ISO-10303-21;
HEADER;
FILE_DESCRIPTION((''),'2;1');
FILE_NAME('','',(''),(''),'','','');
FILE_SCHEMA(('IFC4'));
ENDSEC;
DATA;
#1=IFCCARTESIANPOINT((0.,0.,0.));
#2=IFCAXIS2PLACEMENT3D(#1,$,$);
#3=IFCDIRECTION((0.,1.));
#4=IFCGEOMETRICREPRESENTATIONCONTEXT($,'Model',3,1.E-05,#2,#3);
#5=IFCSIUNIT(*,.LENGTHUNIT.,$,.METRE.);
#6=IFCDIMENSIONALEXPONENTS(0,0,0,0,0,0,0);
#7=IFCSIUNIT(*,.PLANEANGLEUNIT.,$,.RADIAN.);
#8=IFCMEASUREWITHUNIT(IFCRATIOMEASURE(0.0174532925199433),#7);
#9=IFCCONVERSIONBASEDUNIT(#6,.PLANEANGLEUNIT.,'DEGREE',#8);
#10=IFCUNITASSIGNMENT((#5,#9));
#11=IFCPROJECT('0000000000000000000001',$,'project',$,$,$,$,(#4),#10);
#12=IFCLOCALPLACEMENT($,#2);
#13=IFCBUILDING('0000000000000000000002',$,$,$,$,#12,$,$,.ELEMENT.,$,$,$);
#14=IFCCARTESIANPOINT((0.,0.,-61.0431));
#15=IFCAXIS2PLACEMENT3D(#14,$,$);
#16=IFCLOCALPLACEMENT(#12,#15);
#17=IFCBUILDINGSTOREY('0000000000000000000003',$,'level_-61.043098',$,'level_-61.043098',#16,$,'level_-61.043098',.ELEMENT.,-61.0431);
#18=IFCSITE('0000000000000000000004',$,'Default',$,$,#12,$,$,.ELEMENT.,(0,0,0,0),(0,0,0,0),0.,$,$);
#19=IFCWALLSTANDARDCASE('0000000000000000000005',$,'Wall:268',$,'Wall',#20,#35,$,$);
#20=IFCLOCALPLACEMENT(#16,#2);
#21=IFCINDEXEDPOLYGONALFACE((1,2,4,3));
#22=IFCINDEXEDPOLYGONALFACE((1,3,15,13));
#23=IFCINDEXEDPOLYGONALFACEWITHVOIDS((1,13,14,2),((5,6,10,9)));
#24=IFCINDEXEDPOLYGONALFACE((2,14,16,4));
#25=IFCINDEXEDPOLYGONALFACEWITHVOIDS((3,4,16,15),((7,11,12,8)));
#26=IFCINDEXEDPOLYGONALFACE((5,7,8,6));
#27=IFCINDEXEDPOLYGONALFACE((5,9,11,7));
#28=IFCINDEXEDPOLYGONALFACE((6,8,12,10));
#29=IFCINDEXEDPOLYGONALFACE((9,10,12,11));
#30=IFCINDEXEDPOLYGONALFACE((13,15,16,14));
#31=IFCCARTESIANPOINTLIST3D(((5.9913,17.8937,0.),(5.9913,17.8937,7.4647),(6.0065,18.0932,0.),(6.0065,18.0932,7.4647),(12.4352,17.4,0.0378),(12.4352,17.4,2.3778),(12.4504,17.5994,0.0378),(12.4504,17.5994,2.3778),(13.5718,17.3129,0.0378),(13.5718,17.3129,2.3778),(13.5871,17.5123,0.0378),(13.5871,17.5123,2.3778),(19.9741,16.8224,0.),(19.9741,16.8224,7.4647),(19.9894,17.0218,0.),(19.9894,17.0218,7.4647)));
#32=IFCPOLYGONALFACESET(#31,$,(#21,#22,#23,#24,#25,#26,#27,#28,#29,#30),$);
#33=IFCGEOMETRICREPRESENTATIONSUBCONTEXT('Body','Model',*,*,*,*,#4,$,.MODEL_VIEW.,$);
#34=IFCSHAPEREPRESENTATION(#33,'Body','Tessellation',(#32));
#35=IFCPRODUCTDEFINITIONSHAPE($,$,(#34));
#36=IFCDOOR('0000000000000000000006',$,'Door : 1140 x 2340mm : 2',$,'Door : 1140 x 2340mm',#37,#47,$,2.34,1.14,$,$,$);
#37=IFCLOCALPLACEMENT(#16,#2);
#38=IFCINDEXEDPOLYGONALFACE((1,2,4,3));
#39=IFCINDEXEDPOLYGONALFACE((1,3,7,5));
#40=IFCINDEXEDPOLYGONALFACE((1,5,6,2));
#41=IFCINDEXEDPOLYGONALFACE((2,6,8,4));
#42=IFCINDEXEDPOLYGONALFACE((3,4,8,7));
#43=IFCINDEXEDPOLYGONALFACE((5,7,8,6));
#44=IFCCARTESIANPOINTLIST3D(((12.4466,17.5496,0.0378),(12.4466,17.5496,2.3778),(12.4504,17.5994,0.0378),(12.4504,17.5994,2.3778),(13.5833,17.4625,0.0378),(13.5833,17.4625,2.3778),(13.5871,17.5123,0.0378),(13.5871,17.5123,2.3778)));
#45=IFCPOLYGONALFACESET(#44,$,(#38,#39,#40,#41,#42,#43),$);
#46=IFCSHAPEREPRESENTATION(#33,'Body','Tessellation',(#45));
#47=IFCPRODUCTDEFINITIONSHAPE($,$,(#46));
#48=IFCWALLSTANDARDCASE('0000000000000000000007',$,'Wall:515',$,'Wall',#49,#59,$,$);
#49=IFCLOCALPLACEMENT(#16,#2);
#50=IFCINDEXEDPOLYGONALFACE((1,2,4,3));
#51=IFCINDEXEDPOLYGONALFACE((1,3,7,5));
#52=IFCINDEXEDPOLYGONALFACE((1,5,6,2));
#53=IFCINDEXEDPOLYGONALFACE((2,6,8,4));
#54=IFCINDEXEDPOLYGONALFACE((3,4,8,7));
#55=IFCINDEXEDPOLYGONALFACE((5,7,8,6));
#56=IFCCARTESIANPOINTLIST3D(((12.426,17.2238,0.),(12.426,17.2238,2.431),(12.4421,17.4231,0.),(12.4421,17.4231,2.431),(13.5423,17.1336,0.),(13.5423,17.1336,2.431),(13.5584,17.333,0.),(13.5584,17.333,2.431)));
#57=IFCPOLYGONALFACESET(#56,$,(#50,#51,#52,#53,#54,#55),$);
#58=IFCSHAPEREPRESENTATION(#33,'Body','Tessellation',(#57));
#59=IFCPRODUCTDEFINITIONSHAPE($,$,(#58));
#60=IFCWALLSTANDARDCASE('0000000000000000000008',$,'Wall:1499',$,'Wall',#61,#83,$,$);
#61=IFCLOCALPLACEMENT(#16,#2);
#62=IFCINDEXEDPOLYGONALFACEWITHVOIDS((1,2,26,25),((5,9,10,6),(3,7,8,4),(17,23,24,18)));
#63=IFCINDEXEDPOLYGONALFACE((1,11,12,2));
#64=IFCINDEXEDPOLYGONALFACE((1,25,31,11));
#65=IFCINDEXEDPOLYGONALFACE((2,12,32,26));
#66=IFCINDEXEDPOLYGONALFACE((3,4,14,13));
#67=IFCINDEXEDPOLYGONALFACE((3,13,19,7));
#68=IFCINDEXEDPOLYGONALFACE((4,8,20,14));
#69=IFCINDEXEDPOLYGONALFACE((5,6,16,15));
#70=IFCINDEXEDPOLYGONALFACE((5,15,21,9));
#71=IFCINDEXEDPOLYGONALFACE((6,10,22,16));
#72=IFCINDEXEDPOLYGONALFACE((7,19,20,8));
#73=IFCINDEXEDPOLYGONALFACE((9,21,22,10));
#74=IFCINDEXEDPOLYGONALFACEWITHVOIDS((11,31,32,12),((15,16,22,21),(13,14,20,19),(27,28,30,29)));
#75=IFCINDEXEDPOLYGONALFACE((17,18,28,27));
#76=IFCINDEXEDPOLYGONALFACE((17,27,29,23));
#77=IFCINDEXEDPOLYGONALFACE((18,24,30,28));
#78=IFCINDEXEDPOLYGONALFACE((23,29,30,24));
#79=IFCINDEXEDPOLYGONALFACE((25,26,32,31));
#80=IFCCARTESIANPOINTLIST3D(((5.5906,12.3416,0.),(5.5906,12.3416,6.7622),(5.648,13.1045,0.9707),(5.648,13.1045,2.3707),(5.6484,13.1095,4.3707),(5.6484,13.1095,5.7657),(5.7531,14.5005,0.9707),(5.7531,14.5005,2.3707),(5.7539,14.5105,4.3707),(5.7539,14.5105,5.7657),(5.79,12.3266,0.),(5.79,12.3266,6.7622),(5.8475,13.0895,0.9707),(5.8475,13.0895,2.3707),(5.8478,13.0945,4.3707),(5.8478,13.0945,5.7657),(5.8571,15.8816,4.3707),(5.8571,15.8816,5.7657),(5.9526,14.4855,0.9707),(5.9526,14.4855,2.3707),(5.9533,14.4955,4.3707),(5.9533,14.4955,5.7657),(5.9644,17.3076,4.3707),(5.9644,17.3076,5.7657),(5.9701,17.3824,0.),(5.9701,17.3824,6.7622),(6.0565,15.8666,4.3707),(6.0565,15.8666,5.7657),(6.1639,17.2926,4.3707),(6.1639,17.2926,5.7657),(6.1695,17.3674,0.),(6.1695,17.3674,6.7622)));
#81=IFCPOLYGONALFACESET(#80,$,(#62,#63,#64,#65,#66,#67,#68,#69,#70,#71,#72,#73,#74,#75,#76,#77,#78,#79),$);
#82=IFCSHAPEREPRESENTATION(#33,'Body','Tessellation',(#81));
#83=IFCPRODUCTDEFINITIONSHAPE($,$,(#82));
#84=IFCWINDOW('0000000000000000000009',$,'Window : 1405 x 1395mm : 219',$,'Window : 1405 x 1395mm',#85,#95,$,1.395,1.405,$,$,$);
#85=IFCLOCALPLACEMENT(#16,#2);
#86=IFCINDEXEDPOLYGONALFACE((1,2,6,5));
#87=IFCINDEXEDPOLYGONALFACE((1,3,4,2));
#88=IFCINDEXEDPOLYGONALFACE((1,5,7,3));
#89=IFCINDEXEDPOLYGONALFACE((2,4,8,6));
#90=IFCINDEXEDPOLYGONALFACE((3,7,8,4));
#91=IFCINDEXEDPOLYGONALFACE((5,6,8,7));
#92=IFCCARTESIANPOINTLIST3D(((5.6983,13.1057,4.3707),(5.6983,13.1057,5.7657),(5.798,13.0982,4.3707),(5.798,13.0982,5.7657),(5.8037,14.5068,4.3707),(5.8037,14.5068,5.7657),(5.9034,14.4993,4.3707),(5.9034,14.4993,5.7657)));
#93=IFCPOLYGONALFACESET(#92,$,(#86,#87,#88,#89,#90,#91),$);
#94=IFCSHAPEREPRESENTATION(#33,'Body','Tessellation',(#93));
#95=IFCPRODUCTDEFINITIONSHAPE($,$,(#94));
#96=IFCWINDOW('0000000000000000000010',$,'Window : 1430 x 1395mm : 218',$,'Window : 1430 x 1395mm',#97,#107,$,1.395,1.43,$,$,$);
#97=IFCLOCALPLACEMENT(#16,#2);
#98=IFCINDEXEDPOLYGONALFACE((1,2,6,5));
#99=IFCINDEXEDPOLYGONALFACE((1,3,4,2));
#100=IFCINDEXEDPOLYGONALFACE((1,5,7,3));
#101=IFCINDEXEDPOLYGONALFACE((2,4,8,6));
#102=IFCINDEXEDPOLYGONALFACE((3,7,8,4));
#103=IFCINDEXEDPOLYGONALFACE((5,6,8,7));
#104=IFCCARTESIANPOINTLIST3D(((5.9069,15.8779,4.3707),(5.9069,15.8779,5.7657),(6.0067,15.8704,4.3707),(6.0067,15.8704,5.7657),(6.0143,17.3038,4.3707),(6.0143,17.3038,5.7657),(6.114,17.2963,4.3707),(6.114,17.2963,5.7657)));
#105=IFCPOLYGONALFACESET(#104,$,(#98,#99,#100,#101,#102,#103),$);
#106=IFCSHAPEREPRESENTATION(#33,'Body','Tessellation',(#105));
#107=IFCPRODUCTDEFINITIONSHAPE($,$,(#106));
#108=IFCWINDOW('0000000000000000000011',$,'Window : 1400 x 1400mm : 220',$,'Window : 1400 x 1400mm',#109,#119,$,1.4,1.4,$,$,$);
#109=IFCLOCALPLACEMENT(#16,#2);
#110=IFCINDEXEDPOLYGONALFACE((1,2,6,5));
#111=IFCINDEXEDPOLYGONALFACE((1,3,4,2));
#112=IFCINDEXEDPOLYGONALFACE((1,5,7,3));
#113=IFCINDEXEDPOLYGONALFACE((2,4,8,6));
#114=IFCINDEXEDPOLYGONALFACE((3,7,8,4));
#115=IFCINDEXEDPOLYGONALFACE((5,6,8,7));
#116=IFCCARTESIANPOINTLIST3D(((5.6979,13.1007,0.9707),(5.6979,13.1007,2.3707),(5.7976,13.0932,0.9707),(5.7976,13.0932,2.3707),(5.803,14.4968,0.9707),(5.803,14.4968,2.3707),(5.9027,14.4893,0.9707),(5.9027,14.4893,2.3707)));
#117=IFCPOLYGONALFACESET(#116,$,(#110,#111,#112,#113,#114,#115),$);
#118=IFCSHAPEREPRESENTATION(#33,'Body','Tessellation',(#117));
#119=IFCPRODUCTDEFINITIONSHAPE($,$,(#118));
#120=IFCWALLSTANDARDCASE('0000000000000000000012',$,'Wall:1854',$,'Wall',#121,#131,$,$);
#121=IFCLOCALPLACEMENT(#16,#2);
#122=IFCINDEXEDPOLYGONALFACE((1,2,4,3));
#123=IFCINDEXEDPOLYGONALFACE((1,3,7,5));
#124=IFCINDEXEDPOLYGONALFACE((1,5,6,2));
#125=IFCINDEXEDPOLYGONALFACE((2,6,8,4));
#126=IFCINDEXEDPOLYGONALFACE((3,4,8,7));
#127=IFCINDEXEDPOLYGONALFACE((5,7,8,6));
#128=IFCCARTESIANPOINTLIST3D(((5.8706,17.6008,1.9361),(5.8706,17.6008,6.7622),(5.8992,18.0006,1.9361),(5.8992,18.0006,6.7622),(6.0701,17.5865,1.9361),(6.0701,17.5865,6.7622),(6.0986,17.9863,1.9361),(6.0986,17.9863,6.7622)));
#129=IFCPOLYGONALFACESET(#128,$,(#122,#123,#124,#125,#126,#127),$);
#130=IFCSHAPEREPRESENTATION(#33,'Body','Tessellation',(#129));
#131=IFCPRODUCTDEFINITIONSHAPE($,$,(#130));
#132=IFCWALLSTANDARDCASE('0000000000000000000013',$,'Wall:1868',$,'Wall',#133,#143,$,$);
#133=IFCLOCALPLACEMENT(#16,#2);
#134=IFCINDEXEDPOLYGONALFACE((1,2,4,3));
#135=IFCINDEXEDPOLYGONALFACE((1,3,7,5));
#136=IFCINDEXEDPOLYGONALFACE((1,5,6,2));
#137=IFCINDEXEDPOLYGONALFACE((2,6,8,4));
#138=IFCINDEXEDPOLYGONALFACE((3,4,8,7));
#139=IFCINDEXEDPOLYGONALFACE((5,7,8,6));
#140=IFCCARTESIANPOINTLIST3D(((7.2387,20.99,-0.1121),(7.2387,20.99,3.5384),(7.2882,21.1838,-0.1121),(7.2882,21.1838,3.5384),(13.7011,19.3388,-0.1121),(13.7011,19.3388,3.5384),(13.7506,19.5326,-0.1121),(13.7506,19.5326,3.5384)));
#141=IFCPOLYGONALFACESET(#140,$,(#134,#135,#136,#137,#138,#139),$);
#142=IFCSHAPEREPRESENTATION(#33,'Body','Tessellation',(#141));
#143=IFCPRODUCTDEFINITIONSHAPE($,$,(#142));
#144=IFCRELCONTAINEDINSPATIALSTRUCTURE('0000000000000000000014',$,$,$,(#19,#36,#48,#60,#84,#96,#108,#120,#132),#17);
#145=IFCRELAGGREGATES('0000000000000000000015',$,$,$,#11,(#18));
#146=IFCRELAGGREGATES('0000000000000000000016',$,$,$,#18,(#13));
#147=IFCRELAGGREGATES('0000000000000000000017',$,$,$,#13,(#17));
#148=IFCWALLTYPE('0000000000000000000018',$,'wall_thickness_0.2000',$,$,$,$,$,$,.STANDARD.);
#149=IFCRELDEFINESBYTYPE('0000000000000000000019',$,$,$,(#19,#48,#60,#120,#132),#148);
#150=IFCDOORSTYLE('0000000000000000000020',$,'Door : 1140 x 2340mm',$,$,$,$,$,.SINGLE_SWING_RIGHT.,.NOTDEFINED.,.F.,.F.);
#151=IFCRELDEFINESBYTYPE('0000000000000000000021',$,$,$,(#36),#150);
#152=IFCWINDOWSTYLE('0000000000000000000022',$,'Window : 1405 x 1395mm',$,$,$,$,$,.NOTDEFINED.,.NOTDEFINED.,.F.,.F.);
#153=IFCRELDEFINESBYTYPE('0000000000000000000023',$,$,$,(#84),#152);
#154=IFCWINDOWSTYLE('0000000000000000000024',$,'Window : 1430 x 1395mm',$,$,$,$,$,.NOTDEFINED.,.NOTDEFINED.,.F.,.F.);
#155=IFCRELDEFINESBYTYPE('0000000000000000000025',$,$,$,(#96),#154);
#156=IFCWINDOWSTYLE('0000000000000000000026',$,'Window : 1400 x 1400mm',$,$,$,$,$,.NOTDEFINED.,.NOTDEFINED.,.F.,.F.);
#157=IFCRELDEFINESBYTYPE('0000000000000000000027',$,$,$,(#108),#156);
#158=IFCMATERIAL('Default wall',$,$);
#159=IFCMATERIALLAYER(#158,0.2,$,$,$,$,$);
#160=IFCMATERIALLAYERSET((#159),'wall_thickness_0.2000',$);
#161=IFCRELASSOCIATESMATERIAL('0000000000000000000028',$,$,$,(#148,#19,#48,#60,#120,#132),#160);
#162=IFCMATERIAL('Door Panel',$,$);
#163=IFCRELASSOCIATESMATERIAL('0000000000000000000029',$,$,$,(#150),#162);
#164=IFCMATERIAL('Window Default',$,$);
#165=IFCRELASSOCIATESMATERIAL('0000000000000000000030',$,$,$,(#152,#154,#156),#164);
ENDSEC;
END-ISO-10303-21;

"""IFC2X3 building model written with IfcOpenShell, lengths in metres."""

from ifc_helpers import new_model, entity, si_unit, converted_unit, direction, frame, frame_2d, origin, origin_2d_with_axis, place, context, subcontext, project, spatial, polyline, rectangle, outline, extrude, source, transform, mapped, material, layer, layer_set, layer_usage, type_object, type_shapes, element, fill, save


model = new_model("IFC2X3")

# Units and contexts
model_context = context("Model", 3, precision=1e-05, world=origin(), true_north=direction((0.0, 1.0)))
body_context = subcontext(model_context, "Body", "Model", "MODEL_VIEW")
ifc_project = project(units=[si_unit("LENGTHUNIT", "METRE"), converted_unit("PLANEANGLEUNIT", "DEGREE", entity("IfcRatioMeasure", 0.0174532925199433), si_unit("PLANEANGLEUNIT", "RADIAN"), dimensions=[0, 0, 0, 0, 0, 0, 0])], contexts=[model_context])

# Site, building, storey
placement_1 = place(None, origin())
site = spatial("IfcSite", under=ifc_project, at=placement_1, Name="Default", CompositionType="ELEMENT", RefLatitude=(0, 0, 0, 0), RefLongitude=(0, 0, 0, 0), RefElevation=0.0)
building = spatial("IfcBuilding", under=site, at=placement_1, CompositionType="ELEMENT")
storey_placement = place(placement_1, frame((0.0, 0.0, -61.0431)))
storey = spatial("IfcBuildingStorey", under=building, at=storey_placement, Name="level_-61.043098", ObjectType="level_-61.043098", LongName="level_-61.043098", CompositionType="ELEMENT", Elevation=-61.0431)

# Wall, opening, door
ifc_material_1 = material(Name="Default wall")
ifc_layer = layer(ifc_material_1, 0.2)
ifc_layer_set = layer_set([ifc_layer], Name="wall_thickness_0.2000")
ifc_layer_usage = layer_usage(ifc_layer_set, "AXIS2", "POSITIVE", -0.1)
wall_type = type_object("IfcWallType", Name="wall_thickness_0.2000", PredefinedType="STANDARD", material=ifc_layer_set)
wall_1_placement = place(storey_placement, frame((5.9989, 17.9935, 0.0), z_axis=(0.0, 0.0, 1.0), x_axis=(0.997077, -0.076397, 0.0)))
wall_1 = element("IfcWallStandardCase", 1, at=wall_1_placement, inside=storey, type_object=wall_type, material=ifc_layer_usage, Name="Wall:268", ObjectType="Wall", context=body_context, shape_type="SweptSolid", body=[
    extrude(outline(polyline([(14.0238, -0.1), (14.0238, 0.1), (0.0, 0.1), (0.0, -0.1), (14.0238, -0.1)])), origin(), (0.0, 0.0, 1.0), 7.4647),
])
opening_1_placement = place(wall_1_placement, frame((6.4628, -0.1, 0.0378)))
opening_1 = element("IfcOpeningElement", 2, at=opening_1_placement, cuts=wall_1, ObjectType="Opening", context=body_context, shape_type="SweptSolid", body=[
    extrude(rectangle(XDim=1.14, YDim=2.34, at=frame_2d((1.17, 0.57), x_axis=(0.0, 1.0))), frame((0.0, 0.0, 0.0), z_axis=(0.0, 1.0, 0.0), x_axis=(0.0, 0.0, 1.0)), (0.0, 0.0, 1.0), 0.2),
])
ifc_material_2 = material(Name="Door Panel")
door_style = type_object("IfcDoorStyle", Name="Door : 1140 x 2340mm", ConstructionType="NOTDEFINED", OperationType="SINGLE_SWING_RIGHT", ParameterTakesPrecedence=False, Sizeable=False, material=ifc_material_2)
shared_shape_1 = source(origin(), body_context, "Body", "SweptSolid", [
    extrude(rectangle(XDim=0.05, YDim=1.14, at=origin_2d_with_axis()), frame((0.57, 0.175, 0.0), z_axis=(0.0, 0.0, 1.0), x_axis=(0.0, 1.0, 0.0)), (0.0, 0.0, 1.0), 2.34),
])
type_shapes(door_style, [shared_shape_1])
door_placement = place(opening_1_placement, origin())
door = element("IfcDoor", 3, at=door_placement, inside=storey, type_object=door_style, Name="Door : 1140 x 2340mm : 2", ObjectType="Door : 1140 x 2340mm", OverallHeight=2.34, OverallWidth=1.14, context=body_context, shape_type="MappedRepresentation", body=[
    mapped(shared_shape_1, transform((0.0, 0.0, 0.0), scale=1.0)),
])
fill(opening_1, door)

# Wall
wall_2_placement = place(storey_placement, frame((12.434, 17.3234, 0.0), z_axis=(0.0, 0.0, 1.0), x_axis=(0.996755, -0.080499, 0.0)))
element("IfcWallStandardCase", 4, at=wall_2_placement, inside=storey, type_object=wall_type, material=ifc_layer_usage, Name="Wall:515", ObjectType="Wall", context=body_context, shape_type="SweptSolid", body=[
    extrude(outline(polyline([(1.12, -0.1), (1.12, 0.1), (0.0, 0.1), (0.0, -0.1), (1.12, -0.1)])), origin(), (0.0, 0.0, 1.0), 2.431),
])

# Wall, openings, windows
wall_3_placement = place(storey_placement, frame((6.0698, 17.3749, 0.0), z_axis=(0.0, 0.0, 1.0), x_axis=(-0.075064, -0.997179, 0.0)))
wall_3 = element("IfcWallStandardCase", 5, at=wall_3_placement, inside=storey, type_object=wall_type, material=ifc_layer_usage, Name="Wall:1499", ObjectType="Wall", context=body_context, shape_type="SweptSolid", body=[
    extrude(outline(polyline([(5.055, -0.1), (5.055, 0.1), (0.0, 0.1), (0.0, -0.1), (5.055, -0.1)])), origin(), (0.0, 0.0, 1.0), 6.7622),
])
opening_2_placement = place(wall_3_placement, frame((0.075, -0.1, 4.3707)))
opening_2 = element("IfcOpeningElement", 6, at=opening_2_placement, cuts=wall_3, ObjectType="Opening", context=body_context, shape_type="SweptSolid", body=[
    extrude(rectangle(XDim=1.43, YDim=1.395, at=frame_2d((0.6975, 0.715), x_axis=(0.0, 1.0))), frame((0.0, 0.0, 0.0), z_axis=(0.0, 1.0, 0.0), x_axis=(0.0, 0.0, 1.0)), (0.0, 0.0, 1.0), 0.2),
])
opening_3_placement = place(wall_3_placement, frame((2.88, -0.1, 4.3707)))
opening_3 = element("IfcOpeningElement", 7, at=opening_3_placement, cuts=wall_3, ObjectType="Opening", context=body_context, shape_type="SweptSolid", body=[
    extrude(rectangle(XDim=1.405, YDim=1.395, at=frame_2d((0.6975, 0.7025), x_axis=(0.0, 1.0))), frame((0.0, 0.0, 0.0), z_axis=(0.0, 1.0, 0.0), x_axis=(0.0, 0.0, 1.0)), (0.0, 0.0, 1.0), 0.2),
])
opening_4_placement = place(wall_3_placement, frame((2.89, -0.1, 0.9707)))
opening_4 = element("IfcOpeningElement", 8, at=opening_4_placement, cuts=wall_3, ObjectType="Opening", context=body_context, shape_type="SweptSolid", body=[
    extrude(rectangle(XDim=1.4, YDim=1.4, at=frame_2d((0.7, 0.7), x_axis=(0.0, 1.0))), frame((0.0, 0.0, 0.0), z_axis=(0.0, 1.0, 0.0), x_axis=(0.0, 0.0, 1.0)), (0.0, 0.0, 1.0), 0.2),
])
ifc_material_3 = material(Name="Window Default")
window_style_1 = type_object("IfcWindowStyle", Name="Window : 1405 x 1395mm", ConstructionType="NOTDEFINED", OperationType="NOTDEFINED", ParameterTakesPrecedence=False, Sizeable=False, material=ifc_material_3)
shared_shape_2 = source(origin(), body_context, "Body", "SweptSolid", [
    extrude(rectangle(XDim=0.1, YDim=1.405, at=origin_2d_with_axis()), frame((0.7025, 0.1, 0.0), z_axis=(0.0, 0.0, 1.0), x_axis=(0.0, 1.0, 0.0)), (0.0, 0.0, 1.0), 1.395),
])
type_shapes(window_style_1, [shared_shape_2])
window_1_placement = place(opening_3_placement, origin())
window_1 = element("IfcWindow", 9, at=window_1_placement, inside=storey, type_object=window_style_1, Name="Window : 1405 x 1395mm : 219", ObjectType="Window : 1405 x 1395mm", OverallHeight=1.395, OverallWidth=1.405, context=body_context, shape_type="MappedRepresentation", body=[
    mapped(shared_shape_2, transform((0.0, 0.0, 0.0), scale=1.0)),
])
fill(opening_3, window_1)
window_style_2 = type_object("IfcWindowStyle", Name="Window : 1430 x 1395mm", ConstructionType="NOTDEFINED", OperationType="NOTDEFINED", ParameterTakesPrecedence=False, Sizeable=False, material=ifc_material_3)
shared_shape_3 = source(origin(), body_context, "Body", "SweptSolid", [
    extrude(rectangle(XDim=0.1, YDim=1.43, at=origin_2d_with_axis()), frame((0.715, 0.1, 0.0), z_axis=(0.0, 0.0, 1.0), x_axis=(0.0, 1.0, 0.0)), (0.0, 0.0, 1.0), 1.395),
])
type_shapes(window_style_2, [shared_shape_3])
window_2_placement = place(opening_2_placement, origin())
window_2 = element("IfcWindow", 10, at=window_2_placement, inside=storey, type_object=window_style_2, Name="Window : 1430 x 1395mm : 218", ObjectType="Window : 1430 x 1395mm", OverallHeight=1.395, OverallWidth=1.43, context=body_context, shape_type="MappedRepresentation", body=[
    mapped(shared_shape_3, transform((0.0, 0.0, 0.0), scale=1.0)),
])
fill(opening_2, window_2)
window_style_3 = type_object("IfcWindowStyle", Name="Window : 1400 x 1400mm", ConstructionType="NOTDEFINED", OperationType="NOTDEFINED", ParameterTakesPrecedence=False, Sizeable=False, material=ifc_material_3)
shared_shape_4 = source(origin(), body_context, "Body", "SweptSolid", [
    extrude(rectangle(XDim=0.1, YDim=1.4, at=origin_2d_with_axis()), frame((0.7, 0.1, 0.0), z_axis=(0.0, 0.0, 1.0), x_axis=(0.0, 1.0, 0.0)), (0.0, 0.0, 1.0), 1.4),
])
type_shapes(window_style_3, [shared_shape_4])
window_3_placement = place(opening_4_placement, origin())
window_3 = element("IfcWindow", 11, at=window_3_placement, inside=storey, type_object=window_style_3, Name="Window : 1400 x 1400mm : 220", ObjectType="Window : 1400 x 1400mm", OverallHeight=1.4, OverallWidth=1.4, context=body_context, shape_type="MappedRepresentation", body=[
    mapped(shared_shape_4, transform((0.0, 0.0, 0.0), scale=1.0)),
])
fill(opening_4, window_3)

# Walls
placement_2 = place(placement_1, frame((0.0, 0.0, -59.107)))
wall_4_placement = place(placement_2, frame((5.9704, 17.5936, 0.0), z_axis=(0.0, 0.0, 1.0), x_axis=(0.071172, 0.997464, 0.0)))
element("IfcWallStandardCase", 12, at=wall_4_placement, inside=storey, type_object=wall_type, material=ifc_layer_usage, Name="Wall:1854", ObjectType="Wall", context=body_context, shape_type="SweptSolid", body=[
    extrude(outline(polyline([(0.4008, -0.1), (0.4008, 0.1), (0.0, 0.1), (0.0, -0.1), (0.4008, -0.1)])), origin(), (0.0, 0.0, 1.0), 4.8261),
])
placement_3 = place(placement_1, frame((0.0, 0.0, -61.1552)))
wall_5_placement = place(placement_3, frame((7.2634, 21.0869, 0.0), z_axis=(0.0, 0.0, 1.0), x_axis=(0.968874, -0.247554, 0.0)))
element("IfcWallStandardCase", 13, at=wall_5_placement, inside=storey, type_object=wall_type, material=ifc_layer_usage, Name="Wall:1868", ObjectType="Wall", context=body_context, shape_type="SweptSolid", body=[
    extrude(outline(polyline([(6.67, -0.1), (6.67, 0.1), (0.0, 0.1), (0.0, -0.1), (6.67, -0.1)])), origin(), (0.0, 0.0, 1.0), 3.6506),
])

save(model, "model.ifc")
